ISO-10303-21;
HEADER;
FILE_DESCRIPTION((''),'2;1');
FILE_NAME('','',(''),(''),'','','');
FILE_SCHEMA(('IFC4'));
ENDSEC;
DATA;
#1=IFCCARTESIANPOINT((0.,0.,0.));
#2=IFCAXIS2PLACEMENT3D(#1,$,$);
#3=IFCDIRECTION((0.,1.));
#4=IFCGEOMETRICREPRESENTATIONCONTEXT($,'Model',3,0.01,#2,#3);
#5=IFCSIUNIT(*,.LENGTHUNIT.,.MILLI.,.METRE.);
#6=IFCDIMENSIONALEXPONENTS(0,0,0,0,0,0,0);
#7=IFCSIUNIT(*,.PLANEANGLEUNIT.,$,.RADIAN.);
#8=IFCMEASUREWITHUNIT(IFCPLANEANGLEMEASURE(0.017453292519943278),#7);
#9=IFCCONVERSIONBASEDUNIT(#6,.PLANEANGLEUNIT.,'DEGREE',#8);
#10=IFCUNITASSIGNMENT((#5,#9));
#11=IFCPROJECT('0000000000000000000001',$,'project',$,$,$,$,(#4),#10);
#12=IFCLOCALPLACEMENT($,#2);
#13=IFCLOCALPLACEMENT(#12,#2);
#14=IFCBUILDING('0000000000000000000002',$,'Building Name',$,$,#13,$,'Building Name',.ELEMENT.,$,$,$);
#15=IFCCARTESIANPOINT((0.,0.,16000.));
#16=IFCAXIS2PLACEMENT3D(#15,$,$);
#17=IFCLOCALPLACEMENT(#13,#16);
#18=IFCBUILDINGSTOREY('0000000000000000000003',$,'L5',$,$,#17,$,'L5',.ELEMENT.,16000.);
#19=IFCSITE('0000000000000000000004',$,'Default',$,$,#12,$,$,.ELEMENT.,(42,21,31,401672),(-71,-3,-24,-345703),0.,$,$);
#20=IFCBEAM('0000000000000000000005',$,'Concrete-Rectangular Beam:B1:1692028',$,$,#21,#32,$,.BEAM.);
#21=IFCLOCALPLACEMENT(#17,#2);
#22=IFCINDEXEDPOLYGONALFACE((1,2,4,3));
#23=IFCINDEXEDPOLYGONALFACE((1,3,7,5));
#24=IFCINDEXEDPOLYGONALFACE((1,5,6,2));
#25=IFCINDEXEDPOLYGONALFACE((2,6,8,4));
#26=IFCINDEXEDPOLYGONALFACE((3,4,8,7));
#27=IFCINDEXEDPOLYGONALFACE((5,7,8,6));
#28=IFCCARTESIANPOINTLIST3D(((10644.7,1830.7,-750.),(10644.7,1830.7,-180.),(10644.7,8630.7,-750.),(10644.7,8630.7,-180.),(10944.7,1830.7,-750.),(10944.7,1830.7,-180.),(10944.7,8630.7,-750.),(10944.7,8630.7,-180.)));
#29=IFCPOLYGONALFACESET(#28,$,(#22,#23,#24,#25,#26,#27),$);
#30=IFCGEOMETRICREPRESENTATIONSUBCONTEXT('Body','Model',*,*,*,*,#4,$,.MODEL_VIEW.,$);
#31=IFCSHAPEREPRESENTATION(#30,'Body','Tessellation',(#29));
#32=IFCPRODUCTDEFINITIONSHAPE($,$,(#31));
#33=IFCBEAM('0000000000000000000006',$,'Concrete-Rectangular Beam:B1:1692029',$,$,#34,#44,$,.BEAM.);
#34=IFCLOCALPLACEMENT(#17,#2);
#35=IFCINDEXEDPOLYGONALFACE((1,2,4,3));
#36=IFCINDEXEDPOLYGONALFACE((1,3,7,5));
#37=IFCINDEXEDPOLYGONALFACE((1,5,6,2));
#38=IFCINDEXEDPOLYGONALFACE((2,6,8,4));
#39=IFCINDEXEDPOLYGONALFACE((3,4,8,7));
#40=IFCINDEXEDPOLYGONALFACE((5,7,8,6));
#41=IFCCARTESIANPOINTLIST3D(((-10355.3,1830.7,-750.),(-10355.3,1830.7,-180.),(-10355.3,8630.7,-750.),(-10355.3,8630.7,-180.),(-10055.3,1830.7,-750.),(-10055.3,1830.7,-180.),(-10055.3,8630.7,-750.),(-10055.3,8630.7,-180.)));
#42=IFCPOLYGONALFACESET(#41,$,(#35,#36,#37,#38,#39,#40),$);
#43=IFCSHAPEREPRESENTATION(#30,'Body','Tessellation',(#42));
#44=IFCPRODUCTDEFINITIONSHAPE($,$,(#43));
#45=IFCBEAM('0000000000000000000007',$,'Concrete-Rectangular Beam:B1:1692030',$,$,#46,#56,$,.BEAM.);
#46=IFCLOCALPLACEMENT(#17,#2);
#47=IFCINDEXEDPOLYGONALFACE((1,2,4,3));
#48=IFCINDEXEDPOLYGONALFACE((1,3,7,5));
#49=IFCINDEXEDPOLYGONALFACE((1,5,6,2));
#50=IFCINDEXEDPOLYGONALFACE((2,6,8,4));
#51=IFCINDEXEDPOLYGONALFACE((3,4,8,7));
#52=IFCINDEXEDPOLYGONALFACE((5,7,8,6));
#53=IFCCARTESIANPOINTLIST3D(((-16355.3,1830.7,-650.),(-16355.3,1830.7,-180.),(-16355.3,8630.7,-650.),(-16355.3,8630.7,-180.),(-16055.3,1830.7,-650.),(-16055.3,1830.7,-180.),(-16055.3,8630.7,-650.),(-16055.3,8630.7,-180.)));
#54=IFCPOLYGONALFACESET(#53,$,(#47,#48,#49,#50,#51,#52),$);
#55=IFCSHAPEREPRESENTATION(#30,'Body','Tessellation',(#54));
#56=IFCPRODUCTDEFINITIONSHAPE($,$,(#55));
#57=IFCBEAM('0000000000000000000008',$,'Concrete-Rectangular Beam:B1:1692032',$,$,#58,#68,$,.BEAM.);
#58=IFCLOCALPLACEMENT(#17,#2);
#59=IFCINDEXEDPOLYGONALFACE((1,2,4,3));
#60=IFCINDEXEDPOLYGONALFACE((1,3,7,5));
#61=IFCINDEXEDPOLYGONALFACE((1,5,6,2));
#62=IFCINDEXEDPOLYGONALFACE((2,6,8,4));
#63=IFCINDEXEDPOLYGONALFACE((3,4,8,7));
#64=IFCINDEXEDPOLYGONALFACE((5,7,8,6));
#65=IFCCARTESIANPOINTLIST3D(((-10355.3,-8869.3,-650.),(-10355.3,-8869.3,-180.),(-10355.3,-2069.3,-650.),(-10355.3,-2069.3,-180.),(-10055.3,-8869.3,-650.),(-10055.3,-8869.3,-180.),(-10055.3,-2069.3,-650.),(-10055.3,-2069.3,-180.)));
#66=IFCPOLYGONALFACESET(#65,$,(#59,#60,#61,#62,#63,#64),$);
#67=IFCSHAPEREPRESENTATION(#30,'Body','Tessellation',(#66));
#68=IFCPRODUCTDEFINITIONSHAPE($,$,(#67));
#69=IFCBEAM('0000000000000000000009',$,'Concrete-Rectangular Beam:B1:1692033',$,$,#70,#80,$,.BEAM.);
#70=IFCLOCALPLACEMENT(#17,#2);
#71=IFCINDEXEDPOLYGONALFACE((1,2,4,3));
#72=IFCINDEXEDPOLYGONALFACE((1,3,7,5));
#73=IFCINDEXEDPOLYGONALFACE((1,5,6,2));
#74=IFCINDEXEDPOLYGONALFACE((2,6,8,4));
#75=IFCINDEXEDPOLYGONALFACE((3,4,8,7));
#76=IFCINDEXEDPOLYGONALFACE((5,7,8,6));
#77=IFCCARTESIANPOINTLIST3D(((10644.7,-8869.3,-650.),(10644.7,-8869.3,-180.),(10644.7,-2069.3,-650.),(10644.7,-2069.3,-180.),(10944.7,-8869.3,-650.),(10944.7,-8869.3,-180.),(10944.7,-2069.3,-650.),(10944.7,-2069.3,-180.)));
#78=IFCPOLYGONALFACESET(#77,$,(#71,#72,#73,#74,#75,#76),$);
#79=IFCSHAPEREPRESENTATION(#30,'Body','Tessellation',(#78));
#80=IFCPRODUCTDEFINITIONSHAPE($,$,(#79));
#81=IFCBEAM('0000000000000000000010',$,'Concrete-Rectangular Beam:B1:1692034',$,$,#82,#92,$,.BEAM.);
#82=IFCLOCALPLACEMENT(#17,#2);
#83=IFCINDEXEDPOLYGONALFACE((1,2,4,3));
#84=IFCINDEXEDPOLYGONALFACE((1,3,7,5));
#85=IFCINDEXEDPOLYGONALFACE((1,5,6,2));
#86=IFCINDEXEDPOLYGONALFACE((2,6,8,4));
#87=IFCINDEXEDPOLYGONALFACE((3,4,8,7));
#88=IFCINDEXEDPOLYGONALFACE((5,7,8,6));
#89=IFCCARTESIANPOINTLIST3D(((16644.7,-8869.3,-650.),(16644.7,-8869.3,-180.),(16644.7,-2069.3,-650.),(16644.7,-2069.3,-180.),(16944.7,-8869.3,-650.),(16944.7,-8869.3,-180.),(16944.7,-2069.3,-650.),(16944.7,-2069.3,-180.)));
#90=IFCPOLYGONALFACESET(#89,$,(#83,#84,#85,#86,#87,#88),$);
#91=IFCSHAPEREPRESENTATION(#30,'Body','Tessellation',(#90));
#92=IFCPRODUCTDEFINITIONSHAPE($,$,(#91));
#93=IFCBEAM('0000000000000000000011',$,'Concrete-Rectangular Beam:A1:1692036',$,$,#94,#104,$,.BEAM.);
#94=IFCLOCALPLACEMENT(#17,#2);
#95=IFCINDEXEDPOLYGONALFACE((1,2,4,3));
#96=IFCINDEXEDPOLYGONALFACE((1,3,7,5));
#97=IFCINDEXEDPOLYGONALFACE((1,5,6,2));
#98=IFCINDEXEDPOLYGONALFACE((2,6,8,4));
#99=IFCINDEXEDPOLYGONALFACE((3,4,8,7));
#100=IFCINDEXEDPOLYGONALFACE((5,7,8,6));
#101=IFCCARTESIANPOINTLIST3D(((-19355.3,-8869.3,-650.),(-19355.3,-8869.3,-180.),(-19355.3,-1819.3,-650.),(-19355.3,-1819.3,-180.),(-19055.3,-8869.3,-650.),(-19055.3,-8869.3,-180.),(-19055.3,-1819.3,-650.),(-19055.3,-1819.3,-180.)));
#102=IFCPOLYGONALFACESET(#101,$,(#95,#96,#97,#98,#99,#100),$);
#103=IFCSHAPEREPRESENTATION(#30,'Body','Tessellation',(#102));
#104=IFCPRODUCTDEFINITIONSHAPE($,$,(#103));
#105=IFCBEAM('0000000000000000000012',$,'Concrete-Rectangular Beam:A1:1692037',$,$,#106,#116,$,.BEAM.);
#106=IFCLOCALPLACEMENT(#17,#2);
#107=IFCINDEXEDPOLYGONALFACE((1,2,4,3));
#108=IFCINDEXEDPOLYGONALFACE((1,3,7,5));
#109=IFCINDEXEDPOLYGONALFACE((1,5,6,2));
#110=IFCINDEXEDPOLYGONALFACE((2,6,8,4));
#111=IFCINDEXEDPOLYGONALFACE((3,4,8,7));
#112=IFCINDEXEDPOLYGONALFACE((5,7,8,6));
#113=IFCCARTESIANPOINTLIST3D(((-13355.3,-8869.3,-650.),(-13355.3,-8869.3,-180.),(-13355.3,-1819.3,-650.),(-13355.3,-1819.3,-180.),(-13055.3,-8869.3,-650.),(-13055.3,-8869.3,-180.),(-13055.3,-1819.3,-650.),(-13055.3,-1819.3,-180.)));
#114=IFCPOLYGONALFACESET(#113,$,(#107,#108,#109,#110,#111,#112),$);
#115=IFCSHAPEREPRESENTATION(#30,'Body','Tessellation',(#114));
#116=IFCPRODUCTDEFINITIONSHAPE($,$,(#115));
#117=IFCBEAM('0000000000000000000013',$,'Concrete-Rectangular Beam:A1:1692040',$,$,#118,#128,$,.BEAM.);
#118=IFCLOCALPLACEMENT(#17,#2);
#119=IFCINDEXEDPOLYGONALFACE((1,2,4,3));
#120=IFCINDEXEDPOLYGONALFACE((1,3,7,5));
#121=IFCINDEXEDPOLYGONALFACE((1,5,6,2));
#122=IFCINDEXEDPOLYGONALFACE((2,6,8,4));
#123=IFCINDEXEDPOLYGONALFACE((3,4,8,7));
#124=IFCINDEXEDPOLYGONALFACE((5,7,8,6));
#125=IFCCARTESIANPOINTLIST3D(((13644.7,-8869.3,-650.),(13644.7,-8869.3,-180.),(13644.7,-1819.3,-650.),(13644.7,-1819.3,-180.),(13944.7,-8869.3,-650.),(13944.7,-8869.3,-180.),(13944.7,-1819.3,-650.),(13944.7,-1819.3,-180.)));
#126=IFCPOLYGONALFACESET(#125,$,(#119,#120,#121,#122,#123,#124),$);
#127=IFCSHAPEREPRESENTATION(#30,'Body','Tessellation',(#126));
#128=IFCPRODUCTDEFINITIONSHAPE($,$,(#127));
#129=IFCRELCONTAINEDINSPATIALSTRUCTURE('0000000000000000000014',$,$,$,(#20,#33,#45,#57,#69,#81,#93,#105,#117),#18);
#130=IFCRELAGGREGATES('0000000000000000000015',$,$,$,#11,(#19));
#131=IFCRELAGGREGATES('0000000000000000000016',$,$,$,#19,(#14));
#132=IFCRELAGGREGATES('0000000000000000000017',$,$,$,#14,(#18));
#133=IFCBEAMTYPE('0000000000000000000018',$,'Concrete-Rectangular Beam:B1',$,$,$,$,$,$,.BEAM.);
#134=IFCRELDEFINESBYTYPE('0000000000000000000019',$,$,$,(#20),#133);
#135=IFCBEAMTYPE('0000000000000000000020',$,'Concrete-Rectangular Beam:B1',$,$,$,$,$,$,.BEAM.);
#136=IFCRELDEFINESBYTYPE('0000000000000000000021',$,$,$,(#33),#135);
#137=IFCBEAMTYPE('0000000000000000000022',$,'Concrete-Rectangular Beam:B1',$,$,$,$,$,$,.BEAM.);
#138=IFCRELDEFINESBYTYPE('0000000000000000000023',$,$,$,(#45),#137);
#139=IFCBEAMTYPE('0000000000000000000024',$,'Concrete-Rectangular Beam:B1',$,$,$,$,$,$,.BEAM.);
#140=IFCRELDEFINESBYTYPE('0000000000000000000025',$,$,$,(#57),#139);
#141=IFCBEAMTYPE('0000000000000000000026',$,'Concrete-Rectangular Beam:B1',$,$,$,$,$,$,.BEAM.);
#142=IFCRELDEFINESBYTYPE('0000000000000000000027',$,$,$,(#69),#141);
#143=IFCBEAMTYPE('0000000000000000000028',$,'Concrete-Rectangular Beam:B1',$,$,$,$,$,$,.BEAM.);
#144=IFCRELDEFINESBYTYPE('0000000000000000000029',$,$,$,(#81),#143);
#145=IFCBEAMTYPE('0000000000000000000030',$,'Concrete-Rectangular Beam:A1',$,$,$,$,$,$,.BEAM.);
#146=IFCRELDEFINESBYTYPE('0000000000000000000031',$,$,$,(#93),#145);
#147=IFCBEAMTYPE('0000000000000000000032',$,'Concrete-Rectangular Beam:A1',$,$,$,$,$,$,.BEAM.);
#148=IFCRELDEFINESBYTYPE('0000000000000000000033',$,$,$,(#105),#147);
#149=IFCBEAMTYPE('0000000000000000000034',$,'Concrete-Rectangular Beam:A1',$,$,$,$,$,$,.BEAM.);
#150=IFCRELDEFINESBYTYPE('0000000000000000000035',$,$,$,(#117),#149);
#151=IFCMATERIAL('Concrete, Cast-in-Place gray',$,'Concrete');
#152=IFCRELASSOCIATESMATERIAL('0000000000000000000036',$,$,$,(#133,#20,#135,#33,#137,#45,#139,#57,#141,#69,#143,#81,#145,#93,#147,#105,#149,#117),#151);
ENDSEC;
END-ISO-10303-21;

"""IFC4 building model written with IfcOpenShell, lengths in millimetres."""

from ifc_helpers import new_model, entity, si_unit, converted_unit, direction, frame, origin, place, context, subcontext, project, spatial, indexed_curve, outline, extrude, source, transform, mapped, material, type_object, type_shapes, element, save


model = new_model("IFC4")

# Units and contexts
model_context = context("Model", 3, precision=0.01, world=origin(), true_north=direction((0.0, 1.0)))
body_context = subcontext(model_context, "Body", "Model", "MODEL_VIEW")
ifc_project = project(units=[si_unit("LENGTHUNIT", "METRE", prefix="MILLI"), converted_unit("PLANEANGLEUNIT", "DEGREE", entity("IfcPlaneAngleMeasure", 0.017453292519943278), si_unit("PLANEANGLEUNIT", "RADIAN"), dimensions=[0, 0, 0, 0, 0, 0, 0])], contexts=[model_context])

# Site, building, storey
site_placement = place(None, origin())
site = spatial("IfcSite", under=ifc_project, at=site_placement, Name="Default", CompositionType="ELEMENT", RefLatitude=(42, 21, 31, 401672), RefLongitude=(-71, -3, -24, -345703), RefElevation=0.0)
building_placement = place(site_placement, origin())
building = spatial("IfcBuilding", under=site, at=building_placement, Name="Building Name", LongName="Building Name", CompositionType="ELEMENT")
storey_placement = place(building_placement, frame((0.0, 0.0, 16000.0)))
storey = spatial("IfcBuildingStorey", under=building, at=storey_placement, Name="L5", LongName="L5", CompositionType="ELEMENT", Elevation=16000.0)

# Shared definitions
ifc_material = material(Name="Concrete, Cast-in-Place gray", Category="Concrete")

# Beams
beam_type_1 = type_object("IfcBeamType", Name="Concrete-Rectangular Beam:B1", PredefinedType="BEAM", material=ifc_material)
shared_shape_1 = source(origin(), body_context, "Body", "SweptSolid", [
    extrude(outline(indexed_curve([(-150.0, -285.0), (150.0, -285.0), (150.0, 285.0), (-150.0, 285.0), (-150.0, -285.0)], self_intersect=False)), frame((10794.7, 8630.7, 15535.0), z_axis=(0.0, -1.0, 0.0), x_axis=(-1.0, 0.0, 0.0)), (0.0, 0.0, 1.0), 6800.0),
])
type_shapes(beam_type_1, [shared_shape_1])
beam_1_placement = place(storey_placement, frame((0.0, 0.0, -16000.0)))
element("IfcBeam", 1, at=beam_1_placement, inside=storey, type_object=beam_type_1, material=ifc_material, Name="Concrete-Rectangular Beam:B1:1692028", PredefinedType="BEAM", context=body_context, shape_type="MappedRepresentation", body=[
    mapped(shared_shape_1, transform((0.0, 0.0, 0.0), scale=1.0)),
])
beam_type_2 = type_object("IfcBeamType", Name="Concrete-Rectangular Beam:B1", PredefinedType="BEAM", material=ifc_material)
shared_shape_2 = source(origin(), body_context, "Body", "SweptSolid", [
    extrude(outline(indexed_curve([(-150.0, -285.0), (150.0, -285.0), (150.0, 285.0), (-150.0, 285.0), (-150.0, -285.0)], self_intersect=False)), frame((-10205.3, 8630.7, 15535.0), z_axis=(0.0, -1.0, 0.0), x_axis=(-1.0, 0.0, 0.0)), (0.0, 0.0, 1.0), 6800.0),
])
type_shapes(beam_type_2, [shared_shape_2])
beam_2_placement = place(storey_placement, frame((0.0, 0.0, -16000.0)))
element("IfcBeam", 2, at=beam_2_placement, inside=storey, type_object=beam_type_2, material=ifc_material, Name="Concrete-Rectangular Beam:B1:1692029", PredefinedType="BEAM", context=body_context, shape_type="MappedRepresentation", body=[
    mapped(shared_shape_2, transform((0.0, 0.0, 0.0), scale=1.0)),
])
beam_type_3 = type_object("IfcBeamType", Name="Concrete-Rectangular Beam:B1", PredefinedType="BEAM", material=ifc_material)
shared_shape_3 = source(origin(), body_context, "Body", "SweptSolid", [
    extrude(outline(indexed_curve([(-150.0, -235.0), (150.0, -235.0), (150.0, 235.0), (-150.0, 235.0), (-150.0, -235.0)], self_intersect=False)), frame((-16205.3, 8630.7, 15585.0), z_axis=(0.0, -1.0, 0.0), x_axis=(-1.0, 0.0, 0.0)), (0.0, 0.0, 1.0), 6800.0),
])
type_shapes(beam_type_3, [shared_shape_3])
beam_3_placement = place(storey_placement, frame((0.0, 0.0, -16000.0)))
element("IfcBeam", 3, at=beam_3_placement, inside=storey, type_object=beam_type_3, material=ifc_material, Name="Concrete-Rectangular Beam:B1:1692030", PredefinedType="BEAM", context=body_context, shape_type="MappedRepresentation", body=[
    mapped(shared_shape_3, transform((0.0, 0.0, 0.0), scale=1.0)),
])
beam_type_4 = type_object("IfcBeamType", Name="Concrete-Rectangular Beam:B1", PredefinedType="BEAM", material=ifc_material)
shared_shape_4 = source(origin(), body_context, "Body", "SweptSolid", [
    extrude(outline(indexed_curve([(-150.0, -235.0), (150.0, -235.0), (150.0, 235.0), (-150.0, 235.0), (-150.0, -235.0)], self_intersect=False)), frame((-10205.3, -8869.3, 15585.0), z_axis=(0.0, 1.0, 0.0), x_axis=(-1.0, 0.0, 0.0)), (0.0, 0.0, 1.0), 6800.0),
])
type_shapes(beam_type_4, [shared_shape_4])
beam_4_placement = place(storey_placement, frame((0.0, 0.0, -16000.0)))
element("IfcBeam", 4, at=beam_4_placement, inside=storey, type_object=beam_type_4, material=ifc_material, Name="Concrete-Rectangular Beam:B1:1692032", PredefinedType="BEAM", context=body_context, shape_type="MappedRepresentation", body=[
    mapped(shared_shape_4, transform((0.0, 0.0, 0.0), scale=1.0)),
])
beam_type_5 = type_object("IfcBeamType", Name="Concrete-Rectangular Beam:B1", PredefinedType="BEAM", material=ifc_material)
shared_shape_5 = source(origin(), body_context, "Body", "SweptSolid", [
    extrude(outline(indexed_curve([(-150.0, -235.0), (150.0, -235.0), (150.0, 235.0), (-150.0, 235.0), (-150.0, -235.0)], self_intersect=False)), frame((10794.7, -8869.3, 15585.0), z_axis=(0.0, 1.0, 0.0), x_axis=(-1.0, 0.0, 0.0)), (0.0, 0.0, 1.0), 6800.0),
])
type_shapes(beam_type_5, [shared_shape_5])
beam_5_placement = place(storey_placement, frame((0.0, 0.0, -16000.0)))
element("IfcBeam", 5, at=beam_5_placement, inside=storey, type_object=beam_type_5, material=ifc_material, Name="Concrete-Rectangular Beam:B1:1692033", PredefinedType="BEAM", context=body_context, shape_type="MappedRepresentation", body=[
    mapped(shared_shape_5, transform((0.0, 0.0, 0.0), scale=1.0)),
])
beam_type_6 = type_object("IfcBeamType", Name="Concrete-Rectangular Beam:B1", PredefinedType="BEAM", material=ifc_material)
shared_shape_6 = source(origin(), body_context, "Body", "SweptSolid", [
    extrude(outline(indexed_curve([(-150.0, -235.0), (150.0, -235.0), (150.0, 235.0), (-150.0, 235.0), (-150.0, -235.0)], self_intersect=False)), frame((16794.7, -8869.3, 15585.0), z_axis=(0.0, 1.0, 0.0), x_axis=(-1.0, 0.0, 0.0)), (0.0, 0.0, 1.0), 6800.0),
])
type_shapes(beam_type_6, [shared_shape_6])
beam_6_placement = place(storey_placement, frame((0.0, 0.0, -16000.0)))
element("IfcBeam", 6, at=beam_6_placement, inside=storey, type_object=beam_type_6, material=ifc_material, Name="Concrete-Rectangular Beam:B1:1692034", PredefinedType="BEAM", context=body_context, shape_type="MappedRepresentation", body=[
    mapped(shared_shape_6, transform((0.0, 0.0, 0.0), scale=1.0)),
])
beam_type_7 = type_object("IfcBeamType", Name="Concrete-Rectangular Beam:A1", PredefinedType="BEAM", material=ifc_material)
shared_shape_7 = source(origin(), body_context, "Body", "SweptSolid", [
    extrude(outline(indexed_curve([(-150.0, -235.0), (150.0, -235.0), (150.0, 235.0), (-150.0, 235.0), (-150.0, -235.0)], self_intersect=False)), frame((-19205.3, -8869.3, 15585.0), z_axis=(0.0, 1.0, 0.0), x_axis=(-1.0, 0.0, 0.0)), (0.0, 0.0, 1.0), 7050.0),
])
type_shapes(beam_type_7, [shared_shape_7])
beam_7_placement = place(storey_placement, frame((0.0, 0.0, -16000.0)))
element("IfcBeam", 7, at=beam_7_placement, inside=storey, type_object=beam_type_7, material=ifc_material, Name="Concrete-Rectangular Beam:A1:1692036", PredefinedType="BEAM", context=body_context, shape_type="MappedRepresentation", body=[
    mapped(shared_shape_7, transform((0.0, 0.0, 0.0), scale=1.0)),
])
beam_type_8 = type_object("IfcBeamType", Name="Concrete-Rectangular Beam:A1", PredefinedType="BEAM", material=ifc_material)
shared_shape_8 = source(origin(), body_context, "Body", "SweptSolid", [
    extrude(outline(indexed_curve([(-150.0, -235.0), (150.0, -235.0), (150.0, 235.0), (-150.0, 235.0), (-150.0, -235.0)], self_intersect=False)), frame((-13205.3, -8869.3, 15585.0), z_axis=(0.0, 1.0, 0.0), x_axis=(-1.0, 0.0, 0.0)), (0.0, 0.0, 1.0), 7050.0),
])
type_shapes(beam_type_8, [shared_shape_8])
beam_8_placement = place(storey_placement, frame((0.0, 0.0, -16000.0)))
element("IfcBeam", 8, at=beam_8_placement, inside=storey, type_object=beam_type_8, material=ifc_material, Name="Concrete-Rectangular Beam:A1:1692037", PredefinedType="BEAM", context=body_context, shape_type="MappedRepresentation", body=[
    mapped(shared_shape_8, transform((0.0, 0.0, 0.0), scale=1.0)),
])
beam_type_9 = type_object("IfcBeamType", Name="Concrete-Rectangular Beam:A1", PredefinedType="BEAM", material=ifc_material)
shared_shape_9 = source(origin(), body_context, "Body", "SweptSolid", [
    extrude(outline(indexed_curve([(-150.0, -235.0), (150.0, -235.0), (150.0, 235.0), (-150.0, 235.0), (-150.0, -235.0)], self_intersect=False)), frame((13794.7, -8869.3, 15585.0), z_axis=(0.0, 1.0, 0.0), x_axis=(-1.0, 0.0, 0.0)), (0.0, 0.0, 1.0), 7050.0),
])
type_shapes(beam_type_9, [shared_shape_9])
beam_9_placement = place(storey_placement, frame((0.0, 0.0, -16000.0)))
element("IfcBeam", 9, at=beam_9_placement, inside=storey, type_object=beam_type_9, material=ifc_material, Name="Concrete-Rectangular Beam:A1:1692040", PredefinedType="BEAM", context=body_context, shape_type="MappedRepresentation", body=[
    mapped(shared_shape_9, transform((0.0, 0.0, 0.0), scale=1.0)),
])

save(model, "model.ifc")
